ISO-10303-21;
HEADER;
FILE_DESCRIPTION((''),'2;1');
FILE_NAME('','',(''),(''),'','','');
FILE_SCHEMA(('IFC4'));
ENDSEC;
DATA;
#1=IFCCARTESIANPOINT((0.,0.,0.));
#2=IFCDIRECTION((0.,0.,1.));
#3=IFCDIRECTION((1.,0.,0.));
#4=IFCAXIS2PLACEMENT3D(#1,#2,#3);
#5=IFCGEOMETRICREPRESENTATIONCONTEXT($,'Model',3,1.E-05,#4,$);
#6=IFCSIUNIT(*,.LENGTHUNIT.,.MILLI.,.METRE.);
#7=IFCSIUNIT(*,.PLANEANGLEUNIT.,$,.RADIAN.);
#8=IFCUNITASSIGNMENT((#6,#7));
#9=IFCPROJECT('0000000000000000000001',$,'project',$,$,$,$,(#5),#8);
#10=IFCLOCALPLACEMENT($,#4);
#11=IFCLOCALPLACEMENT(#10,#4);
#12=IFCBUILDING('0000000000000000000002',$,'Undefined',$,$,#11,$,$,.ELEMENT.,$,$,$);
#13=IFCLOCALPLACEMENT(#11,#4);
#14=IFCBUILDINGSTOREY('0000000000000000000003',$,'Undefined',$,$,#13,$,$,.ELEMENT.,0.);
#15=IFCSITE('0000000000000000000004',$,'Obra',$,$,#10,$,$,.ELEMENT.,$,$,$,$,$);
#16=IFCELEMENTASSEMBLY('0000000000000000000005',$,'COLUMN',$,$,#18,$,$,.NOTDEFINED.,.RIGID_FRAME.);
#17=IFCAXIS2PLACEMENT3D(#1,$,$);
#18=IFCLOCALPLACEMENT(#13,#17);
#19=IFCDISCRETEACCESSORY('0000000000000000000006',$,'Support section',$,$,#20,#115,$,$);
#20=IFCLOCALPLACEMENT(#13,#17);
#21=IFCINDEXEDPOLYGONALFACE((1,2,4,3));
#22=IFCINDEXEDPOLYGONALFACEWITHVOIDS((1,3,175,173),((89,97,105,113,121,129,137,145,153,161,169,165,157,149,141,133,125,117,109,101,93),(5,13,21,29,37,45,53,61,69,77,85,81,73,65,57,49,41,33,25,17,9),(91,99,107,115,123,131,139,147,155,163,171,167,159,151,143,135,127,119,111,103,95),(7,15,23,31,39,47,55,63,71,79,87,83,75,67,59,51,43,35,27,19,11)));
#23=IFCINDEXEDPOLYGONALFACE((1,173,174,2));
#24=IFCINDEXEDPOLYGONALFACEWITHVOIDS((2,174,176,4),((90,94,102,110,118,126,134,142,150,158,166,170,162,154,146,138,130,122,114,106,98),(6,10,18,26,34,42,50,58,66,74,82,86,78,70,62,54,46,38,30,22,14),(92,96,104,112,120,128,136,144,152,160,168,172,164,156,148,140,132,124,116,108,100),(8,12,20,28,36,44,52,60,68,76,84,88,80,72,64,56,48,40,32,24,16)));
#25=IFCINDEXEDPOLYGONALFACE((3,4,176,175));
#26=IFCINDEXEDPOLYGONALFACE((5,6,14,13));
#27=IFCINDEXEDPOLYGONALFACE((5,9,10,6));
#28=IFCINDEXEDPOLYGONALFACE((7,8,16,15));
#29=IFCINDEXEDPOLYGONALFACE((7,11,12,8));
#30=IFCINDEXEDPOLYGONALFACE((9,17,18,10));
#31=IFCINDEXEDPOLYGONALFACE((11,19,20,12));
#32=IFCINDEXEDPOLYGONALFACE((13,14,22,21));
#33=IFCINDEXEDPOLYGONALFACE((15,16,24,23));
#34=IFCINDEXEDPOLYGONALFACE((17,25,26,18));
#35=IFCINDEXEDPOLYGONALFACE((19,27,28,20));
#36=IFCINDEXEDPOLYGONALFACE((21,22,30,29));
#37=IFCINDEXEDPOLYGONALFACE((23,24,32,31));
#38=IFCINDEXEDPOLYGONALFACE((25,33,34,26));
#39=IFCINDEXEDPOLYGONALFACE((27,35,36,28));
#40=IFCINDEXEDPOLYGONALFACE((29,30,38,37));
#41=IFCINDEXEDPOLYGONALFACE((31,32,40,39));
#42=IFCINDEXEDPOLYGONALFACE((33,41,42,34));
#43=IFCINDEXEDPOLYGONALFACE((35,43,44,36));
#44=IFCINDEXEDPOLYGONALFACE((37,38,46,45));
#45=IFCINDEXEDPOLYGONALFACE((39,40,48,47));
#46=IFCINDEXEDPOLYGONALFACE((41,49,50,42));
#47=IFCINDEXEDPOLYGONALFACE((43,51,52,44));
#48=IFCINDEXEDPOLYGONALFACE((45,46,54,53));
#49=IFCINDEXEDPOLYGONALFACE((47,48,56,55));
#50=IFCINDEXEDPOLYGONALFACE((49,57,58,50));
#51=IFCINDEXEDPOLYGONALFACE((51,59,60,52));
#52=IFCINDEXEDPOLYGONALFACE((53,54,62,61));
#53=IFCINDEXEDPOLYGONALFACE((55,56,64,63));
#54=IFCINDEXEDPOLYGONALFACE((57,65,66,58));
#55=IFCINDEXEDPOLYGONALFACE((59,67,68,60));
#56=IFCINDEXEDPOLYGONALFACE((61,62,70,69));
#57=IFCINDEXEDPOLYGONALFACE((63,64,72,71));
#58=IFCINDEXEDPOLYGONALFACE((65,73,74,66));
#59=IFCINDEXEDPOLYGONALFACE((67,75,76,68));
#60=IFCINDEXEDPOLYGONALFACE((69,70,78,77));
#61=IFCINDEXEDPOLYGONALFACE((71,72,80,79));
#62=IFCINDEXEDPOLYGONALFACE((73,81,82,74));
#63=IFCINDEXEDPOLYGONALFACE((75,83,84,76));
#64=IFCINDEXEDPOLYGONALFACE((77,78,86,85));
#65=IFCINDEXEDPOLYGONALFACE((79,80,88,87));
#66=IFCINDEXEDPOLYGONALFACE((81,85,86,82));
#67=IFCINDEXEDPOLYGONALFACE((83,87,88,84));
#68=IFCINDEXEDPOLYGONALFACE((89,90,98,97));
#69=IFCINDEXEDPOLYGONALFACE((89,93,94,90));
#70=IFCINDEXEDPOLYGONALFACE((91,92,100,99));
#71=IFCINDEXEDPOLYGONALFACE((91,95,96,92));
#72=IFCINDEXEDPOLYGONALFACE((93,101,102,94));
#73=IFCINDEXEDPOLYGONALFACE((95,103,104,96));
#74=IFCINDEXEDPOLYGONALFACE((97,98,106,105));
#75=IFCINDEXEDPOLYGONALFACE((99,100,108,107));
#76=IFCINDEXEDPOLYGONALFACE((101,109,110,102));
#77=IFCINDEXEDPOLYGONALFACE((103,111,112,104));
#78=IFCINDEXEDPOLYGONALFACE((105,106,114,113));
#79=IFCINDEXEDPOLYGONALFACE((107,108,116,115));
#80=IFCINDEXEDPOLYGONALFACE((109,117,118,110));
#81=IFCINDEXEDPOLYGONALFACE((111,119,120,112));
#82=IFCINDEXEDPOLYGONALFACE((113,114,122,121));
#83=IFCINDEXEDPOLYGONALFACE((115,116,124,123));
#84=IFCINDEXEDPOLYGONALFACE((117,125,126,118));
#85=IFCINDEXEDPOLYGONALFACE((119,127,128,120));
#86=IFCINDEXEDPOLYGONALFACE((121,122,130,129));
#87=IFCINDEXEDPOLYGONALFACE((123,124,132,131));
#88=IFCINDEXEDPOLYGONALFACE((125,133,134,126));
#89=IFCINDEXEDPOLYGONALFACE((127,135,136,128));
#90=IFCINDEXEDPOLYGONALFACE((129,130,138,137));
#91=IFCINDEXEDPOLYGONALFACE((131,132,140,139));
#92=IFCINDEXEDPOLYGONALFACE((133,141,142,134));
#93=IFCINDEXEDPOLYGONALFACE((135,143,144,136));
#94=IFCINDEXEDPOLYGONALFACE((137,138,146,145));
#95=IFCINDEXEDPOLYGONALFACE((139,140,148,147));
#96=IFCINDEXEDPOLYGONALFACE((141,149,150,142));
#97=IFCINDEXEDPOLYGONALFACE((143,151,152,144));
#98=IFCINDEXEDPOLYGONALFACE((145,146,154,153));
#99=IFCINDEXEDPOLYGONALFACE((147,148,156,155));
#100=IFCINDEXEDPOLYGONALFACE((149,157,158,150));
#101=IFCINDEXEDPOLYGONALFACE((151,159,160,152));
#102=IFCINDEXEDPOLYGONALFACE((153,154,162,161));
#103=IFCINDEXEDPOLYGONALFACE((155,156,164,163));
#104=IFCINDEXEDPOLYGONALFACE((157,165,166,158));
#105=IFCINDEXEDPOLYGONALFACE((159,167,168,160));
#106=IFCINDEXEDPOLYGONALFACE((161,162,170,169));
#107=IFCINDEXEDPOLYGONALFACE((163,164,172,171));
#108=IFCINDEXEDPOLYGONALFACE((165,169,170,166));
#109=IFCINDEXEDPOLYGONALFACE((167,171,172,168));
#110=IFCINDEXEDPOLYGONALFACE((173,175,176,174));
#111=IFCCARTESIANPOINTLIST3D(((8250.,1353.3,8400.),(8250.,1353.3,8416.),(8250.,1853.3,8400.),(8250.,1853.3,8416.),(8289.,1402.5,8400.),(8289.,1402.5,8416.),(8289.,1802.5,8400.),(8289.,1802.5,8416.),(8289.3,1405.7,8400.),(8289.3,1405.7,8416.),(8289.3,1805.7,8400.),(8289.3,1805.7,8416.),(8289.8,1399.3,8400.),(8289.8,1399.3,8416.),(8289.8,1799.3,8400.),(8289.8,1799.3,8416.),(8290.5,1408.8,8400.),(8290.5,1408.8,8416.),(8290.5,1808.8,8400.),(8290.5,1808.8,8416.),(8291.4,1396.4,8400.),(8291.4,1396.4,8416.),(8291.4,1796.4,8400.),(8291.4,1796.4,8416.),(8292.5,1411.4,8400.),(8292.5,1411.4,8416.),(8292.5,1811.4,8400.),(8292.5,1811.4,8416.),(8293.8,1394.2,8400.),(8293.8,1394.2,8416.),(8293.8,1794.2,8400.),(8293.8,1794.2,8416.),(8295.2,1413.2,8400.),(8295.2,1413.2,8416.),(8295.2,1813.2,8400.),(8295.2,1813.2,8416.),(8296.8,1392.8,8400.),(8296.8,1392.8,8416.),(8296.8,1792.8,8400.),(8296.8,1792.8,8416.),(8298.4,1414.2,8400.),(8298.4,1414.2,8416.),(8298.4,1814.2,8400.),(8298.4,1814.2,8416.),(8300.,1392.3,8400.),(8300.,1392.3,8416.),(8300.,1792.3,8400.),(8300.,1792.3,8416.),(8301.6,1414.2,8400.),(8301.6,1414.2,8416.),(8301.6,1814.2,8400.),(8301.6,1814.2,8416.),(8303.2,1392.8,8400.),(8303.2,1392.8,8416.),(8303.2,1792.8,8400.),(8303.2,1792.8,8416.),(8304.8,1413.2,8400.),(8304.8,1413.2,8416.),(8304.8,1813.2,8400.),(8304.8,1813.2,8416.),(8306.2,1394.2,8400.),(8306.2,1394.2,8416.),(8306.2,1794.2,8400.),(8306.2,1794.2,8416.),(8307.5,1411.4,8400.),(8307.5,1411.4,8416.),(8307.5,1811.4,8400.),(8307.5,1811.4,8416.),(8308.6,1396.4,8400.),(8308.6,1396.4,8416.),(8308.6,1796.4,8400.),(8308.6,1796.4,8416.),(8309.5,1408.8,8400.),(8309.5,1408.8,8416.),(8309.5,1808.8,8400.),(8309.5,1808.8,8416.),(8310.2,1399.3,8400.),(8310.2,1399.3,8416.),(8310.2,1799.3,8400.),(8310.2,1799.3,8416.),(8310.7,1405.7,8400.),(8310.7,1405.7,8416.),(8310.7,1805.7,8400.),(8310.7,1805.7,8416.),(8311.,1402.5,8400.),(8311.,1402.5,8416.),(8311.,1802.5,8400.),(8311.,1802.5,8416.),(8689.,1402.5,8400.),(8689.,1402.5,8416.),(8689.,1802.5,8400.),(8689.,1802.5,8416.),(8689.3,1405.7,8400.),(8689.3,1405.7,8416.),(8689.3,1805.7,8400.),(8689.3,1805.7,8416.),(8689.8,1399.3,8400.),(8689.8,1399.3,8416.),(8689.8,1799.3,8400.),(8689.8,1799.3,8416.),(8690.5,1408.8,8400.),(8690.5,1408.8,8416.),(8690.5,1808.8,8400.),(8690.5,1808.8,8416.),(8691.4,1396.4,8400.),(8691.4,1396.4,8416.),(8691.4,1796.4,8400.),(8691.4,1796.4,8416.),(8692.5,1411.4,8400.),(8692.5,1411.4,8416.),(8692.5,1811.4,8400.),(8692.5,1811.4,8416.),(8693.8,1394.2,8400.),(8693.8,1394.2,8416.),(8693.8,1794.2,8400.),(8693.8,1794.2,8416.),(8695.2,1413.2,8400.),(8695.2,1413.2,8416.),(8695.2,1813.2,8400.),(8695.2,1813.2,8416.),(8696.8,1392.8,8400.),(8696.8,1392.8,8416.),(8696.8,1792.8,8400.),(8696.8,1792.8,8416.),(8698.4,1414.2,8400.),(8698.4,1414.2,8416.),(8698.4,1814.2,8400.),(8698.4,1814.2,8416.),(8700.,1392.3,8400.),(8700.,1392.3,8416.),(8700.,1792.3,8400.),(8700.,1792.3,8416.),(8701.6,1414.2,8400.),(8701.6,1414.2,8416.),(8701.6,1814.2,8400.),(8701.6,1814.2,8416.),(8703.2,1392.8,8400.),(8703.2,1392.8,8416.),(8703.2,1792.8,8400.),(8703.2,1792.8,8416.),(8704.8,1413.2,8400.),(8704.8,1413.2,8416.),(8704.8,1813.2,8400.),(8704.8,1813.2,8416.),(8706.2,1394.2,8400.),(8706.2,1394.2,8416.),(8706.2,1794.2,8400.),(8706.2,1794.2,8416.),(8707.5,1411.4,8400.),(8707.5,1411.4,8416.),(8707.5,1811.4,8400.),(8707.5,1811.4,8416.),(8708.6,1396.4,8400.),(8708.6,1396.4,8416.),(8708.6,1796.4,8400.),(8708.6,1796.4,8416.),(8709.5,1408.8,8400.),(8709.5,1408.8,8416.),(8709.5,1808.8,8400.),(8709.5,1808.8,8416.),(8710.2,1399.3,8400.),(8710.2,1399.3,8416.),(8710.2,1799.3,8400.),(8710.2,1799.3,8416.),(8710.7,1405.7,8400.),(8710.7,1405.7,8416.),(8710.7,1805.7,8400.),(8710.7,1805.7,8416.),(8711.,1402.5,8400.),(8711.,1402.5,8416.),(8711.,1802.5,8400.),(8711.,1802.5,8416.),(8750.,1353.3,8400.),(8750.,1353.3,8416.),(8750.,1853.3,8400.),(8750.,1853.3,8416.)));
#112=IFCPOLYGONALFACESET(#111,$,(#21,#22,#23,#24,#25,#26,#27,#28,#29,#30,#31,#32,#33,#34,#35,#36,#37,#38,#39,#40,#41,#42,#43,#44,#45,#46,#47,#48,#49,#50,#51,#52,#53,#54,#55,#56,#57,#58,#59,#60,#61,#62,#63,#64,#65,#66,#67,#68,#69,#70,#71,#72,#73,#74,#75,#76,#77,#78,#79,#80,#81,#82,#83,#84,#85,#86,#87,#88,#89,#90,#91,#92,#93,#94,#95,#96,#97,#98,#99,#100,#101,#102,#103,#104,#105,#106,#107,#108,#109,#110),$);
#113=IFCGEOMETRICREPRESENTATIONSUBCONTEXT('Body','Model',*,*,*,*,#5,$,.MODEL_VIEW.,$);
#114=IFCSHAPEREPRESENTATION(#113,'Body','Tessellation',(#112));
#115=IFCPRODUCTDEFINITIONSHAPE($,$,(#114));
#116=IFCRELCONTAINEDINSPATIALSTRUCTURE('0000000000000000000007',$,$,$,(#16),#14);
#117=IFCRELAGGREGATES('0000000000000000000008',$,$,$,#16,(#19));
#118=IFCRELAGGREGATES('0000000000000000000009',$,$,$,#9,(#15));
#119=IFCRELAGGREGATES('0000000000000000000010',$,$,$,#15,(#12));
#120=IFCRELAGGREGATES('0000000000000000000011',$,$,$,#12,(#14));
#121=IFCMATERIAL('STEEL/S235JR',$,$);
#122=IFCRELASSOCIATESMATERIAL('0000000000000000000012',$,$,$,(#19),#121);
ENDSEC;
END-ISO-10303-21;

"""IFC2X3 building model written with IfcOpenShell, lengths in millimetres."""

from ifc_helpers import new_model, si_unit, frame, origin_with_axes, origin_2d_with_axis, place, context, subcontext, project, spatial, rectangle, circle, extrude, source, transform, mapped, material, element, aggregate, save


model = new_model("IFC2X3")

# Units and contexts
model_context = context("Model", 3, precision=1e-05, world=origin_with_axes())
body_context = subcontext(model_context, "Body", "Model", "MODEL_VIEW")
ifc_project = project(units=[si_unit("LENGTHUNIT", "METRE", prefix="MILLI"), si_unit("PLANEANGLEUNIT", "RADIAN")], contexts=[model_context])

# Site, building, storey
site_placement = place(None, origin_with_axes())
site = spatial("IfcSite", under=ifc_project, at=site_placement, Name="Obra", CompositionType="ELEMENT")
building_placement = place(site_placement, origin_with_axes())
building = spatial("IfcBuilding", under=site, at=building_placement, Name="Undefined", CompositionType="ELEMENT")
storey_placement = place(building_placement, origin_with_axes())
storey = spatial("IfcBuildingStorey", under=building, at=storey_placement, Name="Undefined", CompositionType="ELEMENT", Elevation=0.0)

# Element assembly
assembly_1_placement = place(storey_placement, origin_with_axes())
assembly_1 = element("IfcElementAssembly", 1, at=assembly_1_placement, inside=storey, Name="COLUMN", AssemblyPlace="NOTDEFINED", PredefinedType="RIGID_FRAME")
ifc_material_1 = material(Name="STEEL/S235JR")

# Discrete accessory, opening
discrete_accessory_1_placement = place(assembly_1_placement, frame((8500.0, 1353.3, 8408.0), z_axis=(-1.0, 0.0, 0.0), x_axis=(0.0, 1.0, 0.0)))
discrete_accessory_1 = element("IfcDiscreteAccessory", 2, at=discrete_accessory_1_placement, material=ifc_material_1, Name="Support section", context=body_context, shape_type="SweptSolid", body=[
    extrude(rectangle(XDim=16.0, YDim=500.0, at=origin_2d_with_axis()), frame((500.0, 0.0, 0.0), z_axis=(-1.0, 0.0, 0.0), x_axis=(0.0, -1.0, 0.0)), (0.0, 0.0, 1.0), 500.0),
])
shared_shape_1 = source(origin_with_axes(), body_context, "Body", "SweptSolid", [
    extrude(circle(Radius=11.0, at=origin_2d_with_axis()), frame((0.0, -0.1, 0.0), z_axis=(0.0, 1.0, 0.0), x_axis=(1.0, 0.0, 0.0)), (0.0, 0.0, 1.0), 16.2),
])
opening_1_placement = place(assembly_1_placement, frame((8500.0, 1806.3, 8416.0), z_axis=(1.0, 0.0, 0.0), x_axis=(0.0, -1.0, 0.0)))
element("IfcOpeningElement", 3, at=opening_1_placement, cuts=discrete_accessory_1, ObjectType="Opening", context=body_context, shape_type="MappedRepresentation", body=[
    mapped(shared_shape_1, transform((3.0, 0.0, 200.0))),
    mapped(shared_shape_1, transform((3.0, 0.0, -200.0))),
    mapped(shared_shape_1, transform((403.0, 0.0, 200.0))),
    mapped(shared_shape_1, transform((403.0, 0.0, -200.0))),
])
aggregate(assembly_1, [discrete_accessory_1])

save(model, "model.ifc")
